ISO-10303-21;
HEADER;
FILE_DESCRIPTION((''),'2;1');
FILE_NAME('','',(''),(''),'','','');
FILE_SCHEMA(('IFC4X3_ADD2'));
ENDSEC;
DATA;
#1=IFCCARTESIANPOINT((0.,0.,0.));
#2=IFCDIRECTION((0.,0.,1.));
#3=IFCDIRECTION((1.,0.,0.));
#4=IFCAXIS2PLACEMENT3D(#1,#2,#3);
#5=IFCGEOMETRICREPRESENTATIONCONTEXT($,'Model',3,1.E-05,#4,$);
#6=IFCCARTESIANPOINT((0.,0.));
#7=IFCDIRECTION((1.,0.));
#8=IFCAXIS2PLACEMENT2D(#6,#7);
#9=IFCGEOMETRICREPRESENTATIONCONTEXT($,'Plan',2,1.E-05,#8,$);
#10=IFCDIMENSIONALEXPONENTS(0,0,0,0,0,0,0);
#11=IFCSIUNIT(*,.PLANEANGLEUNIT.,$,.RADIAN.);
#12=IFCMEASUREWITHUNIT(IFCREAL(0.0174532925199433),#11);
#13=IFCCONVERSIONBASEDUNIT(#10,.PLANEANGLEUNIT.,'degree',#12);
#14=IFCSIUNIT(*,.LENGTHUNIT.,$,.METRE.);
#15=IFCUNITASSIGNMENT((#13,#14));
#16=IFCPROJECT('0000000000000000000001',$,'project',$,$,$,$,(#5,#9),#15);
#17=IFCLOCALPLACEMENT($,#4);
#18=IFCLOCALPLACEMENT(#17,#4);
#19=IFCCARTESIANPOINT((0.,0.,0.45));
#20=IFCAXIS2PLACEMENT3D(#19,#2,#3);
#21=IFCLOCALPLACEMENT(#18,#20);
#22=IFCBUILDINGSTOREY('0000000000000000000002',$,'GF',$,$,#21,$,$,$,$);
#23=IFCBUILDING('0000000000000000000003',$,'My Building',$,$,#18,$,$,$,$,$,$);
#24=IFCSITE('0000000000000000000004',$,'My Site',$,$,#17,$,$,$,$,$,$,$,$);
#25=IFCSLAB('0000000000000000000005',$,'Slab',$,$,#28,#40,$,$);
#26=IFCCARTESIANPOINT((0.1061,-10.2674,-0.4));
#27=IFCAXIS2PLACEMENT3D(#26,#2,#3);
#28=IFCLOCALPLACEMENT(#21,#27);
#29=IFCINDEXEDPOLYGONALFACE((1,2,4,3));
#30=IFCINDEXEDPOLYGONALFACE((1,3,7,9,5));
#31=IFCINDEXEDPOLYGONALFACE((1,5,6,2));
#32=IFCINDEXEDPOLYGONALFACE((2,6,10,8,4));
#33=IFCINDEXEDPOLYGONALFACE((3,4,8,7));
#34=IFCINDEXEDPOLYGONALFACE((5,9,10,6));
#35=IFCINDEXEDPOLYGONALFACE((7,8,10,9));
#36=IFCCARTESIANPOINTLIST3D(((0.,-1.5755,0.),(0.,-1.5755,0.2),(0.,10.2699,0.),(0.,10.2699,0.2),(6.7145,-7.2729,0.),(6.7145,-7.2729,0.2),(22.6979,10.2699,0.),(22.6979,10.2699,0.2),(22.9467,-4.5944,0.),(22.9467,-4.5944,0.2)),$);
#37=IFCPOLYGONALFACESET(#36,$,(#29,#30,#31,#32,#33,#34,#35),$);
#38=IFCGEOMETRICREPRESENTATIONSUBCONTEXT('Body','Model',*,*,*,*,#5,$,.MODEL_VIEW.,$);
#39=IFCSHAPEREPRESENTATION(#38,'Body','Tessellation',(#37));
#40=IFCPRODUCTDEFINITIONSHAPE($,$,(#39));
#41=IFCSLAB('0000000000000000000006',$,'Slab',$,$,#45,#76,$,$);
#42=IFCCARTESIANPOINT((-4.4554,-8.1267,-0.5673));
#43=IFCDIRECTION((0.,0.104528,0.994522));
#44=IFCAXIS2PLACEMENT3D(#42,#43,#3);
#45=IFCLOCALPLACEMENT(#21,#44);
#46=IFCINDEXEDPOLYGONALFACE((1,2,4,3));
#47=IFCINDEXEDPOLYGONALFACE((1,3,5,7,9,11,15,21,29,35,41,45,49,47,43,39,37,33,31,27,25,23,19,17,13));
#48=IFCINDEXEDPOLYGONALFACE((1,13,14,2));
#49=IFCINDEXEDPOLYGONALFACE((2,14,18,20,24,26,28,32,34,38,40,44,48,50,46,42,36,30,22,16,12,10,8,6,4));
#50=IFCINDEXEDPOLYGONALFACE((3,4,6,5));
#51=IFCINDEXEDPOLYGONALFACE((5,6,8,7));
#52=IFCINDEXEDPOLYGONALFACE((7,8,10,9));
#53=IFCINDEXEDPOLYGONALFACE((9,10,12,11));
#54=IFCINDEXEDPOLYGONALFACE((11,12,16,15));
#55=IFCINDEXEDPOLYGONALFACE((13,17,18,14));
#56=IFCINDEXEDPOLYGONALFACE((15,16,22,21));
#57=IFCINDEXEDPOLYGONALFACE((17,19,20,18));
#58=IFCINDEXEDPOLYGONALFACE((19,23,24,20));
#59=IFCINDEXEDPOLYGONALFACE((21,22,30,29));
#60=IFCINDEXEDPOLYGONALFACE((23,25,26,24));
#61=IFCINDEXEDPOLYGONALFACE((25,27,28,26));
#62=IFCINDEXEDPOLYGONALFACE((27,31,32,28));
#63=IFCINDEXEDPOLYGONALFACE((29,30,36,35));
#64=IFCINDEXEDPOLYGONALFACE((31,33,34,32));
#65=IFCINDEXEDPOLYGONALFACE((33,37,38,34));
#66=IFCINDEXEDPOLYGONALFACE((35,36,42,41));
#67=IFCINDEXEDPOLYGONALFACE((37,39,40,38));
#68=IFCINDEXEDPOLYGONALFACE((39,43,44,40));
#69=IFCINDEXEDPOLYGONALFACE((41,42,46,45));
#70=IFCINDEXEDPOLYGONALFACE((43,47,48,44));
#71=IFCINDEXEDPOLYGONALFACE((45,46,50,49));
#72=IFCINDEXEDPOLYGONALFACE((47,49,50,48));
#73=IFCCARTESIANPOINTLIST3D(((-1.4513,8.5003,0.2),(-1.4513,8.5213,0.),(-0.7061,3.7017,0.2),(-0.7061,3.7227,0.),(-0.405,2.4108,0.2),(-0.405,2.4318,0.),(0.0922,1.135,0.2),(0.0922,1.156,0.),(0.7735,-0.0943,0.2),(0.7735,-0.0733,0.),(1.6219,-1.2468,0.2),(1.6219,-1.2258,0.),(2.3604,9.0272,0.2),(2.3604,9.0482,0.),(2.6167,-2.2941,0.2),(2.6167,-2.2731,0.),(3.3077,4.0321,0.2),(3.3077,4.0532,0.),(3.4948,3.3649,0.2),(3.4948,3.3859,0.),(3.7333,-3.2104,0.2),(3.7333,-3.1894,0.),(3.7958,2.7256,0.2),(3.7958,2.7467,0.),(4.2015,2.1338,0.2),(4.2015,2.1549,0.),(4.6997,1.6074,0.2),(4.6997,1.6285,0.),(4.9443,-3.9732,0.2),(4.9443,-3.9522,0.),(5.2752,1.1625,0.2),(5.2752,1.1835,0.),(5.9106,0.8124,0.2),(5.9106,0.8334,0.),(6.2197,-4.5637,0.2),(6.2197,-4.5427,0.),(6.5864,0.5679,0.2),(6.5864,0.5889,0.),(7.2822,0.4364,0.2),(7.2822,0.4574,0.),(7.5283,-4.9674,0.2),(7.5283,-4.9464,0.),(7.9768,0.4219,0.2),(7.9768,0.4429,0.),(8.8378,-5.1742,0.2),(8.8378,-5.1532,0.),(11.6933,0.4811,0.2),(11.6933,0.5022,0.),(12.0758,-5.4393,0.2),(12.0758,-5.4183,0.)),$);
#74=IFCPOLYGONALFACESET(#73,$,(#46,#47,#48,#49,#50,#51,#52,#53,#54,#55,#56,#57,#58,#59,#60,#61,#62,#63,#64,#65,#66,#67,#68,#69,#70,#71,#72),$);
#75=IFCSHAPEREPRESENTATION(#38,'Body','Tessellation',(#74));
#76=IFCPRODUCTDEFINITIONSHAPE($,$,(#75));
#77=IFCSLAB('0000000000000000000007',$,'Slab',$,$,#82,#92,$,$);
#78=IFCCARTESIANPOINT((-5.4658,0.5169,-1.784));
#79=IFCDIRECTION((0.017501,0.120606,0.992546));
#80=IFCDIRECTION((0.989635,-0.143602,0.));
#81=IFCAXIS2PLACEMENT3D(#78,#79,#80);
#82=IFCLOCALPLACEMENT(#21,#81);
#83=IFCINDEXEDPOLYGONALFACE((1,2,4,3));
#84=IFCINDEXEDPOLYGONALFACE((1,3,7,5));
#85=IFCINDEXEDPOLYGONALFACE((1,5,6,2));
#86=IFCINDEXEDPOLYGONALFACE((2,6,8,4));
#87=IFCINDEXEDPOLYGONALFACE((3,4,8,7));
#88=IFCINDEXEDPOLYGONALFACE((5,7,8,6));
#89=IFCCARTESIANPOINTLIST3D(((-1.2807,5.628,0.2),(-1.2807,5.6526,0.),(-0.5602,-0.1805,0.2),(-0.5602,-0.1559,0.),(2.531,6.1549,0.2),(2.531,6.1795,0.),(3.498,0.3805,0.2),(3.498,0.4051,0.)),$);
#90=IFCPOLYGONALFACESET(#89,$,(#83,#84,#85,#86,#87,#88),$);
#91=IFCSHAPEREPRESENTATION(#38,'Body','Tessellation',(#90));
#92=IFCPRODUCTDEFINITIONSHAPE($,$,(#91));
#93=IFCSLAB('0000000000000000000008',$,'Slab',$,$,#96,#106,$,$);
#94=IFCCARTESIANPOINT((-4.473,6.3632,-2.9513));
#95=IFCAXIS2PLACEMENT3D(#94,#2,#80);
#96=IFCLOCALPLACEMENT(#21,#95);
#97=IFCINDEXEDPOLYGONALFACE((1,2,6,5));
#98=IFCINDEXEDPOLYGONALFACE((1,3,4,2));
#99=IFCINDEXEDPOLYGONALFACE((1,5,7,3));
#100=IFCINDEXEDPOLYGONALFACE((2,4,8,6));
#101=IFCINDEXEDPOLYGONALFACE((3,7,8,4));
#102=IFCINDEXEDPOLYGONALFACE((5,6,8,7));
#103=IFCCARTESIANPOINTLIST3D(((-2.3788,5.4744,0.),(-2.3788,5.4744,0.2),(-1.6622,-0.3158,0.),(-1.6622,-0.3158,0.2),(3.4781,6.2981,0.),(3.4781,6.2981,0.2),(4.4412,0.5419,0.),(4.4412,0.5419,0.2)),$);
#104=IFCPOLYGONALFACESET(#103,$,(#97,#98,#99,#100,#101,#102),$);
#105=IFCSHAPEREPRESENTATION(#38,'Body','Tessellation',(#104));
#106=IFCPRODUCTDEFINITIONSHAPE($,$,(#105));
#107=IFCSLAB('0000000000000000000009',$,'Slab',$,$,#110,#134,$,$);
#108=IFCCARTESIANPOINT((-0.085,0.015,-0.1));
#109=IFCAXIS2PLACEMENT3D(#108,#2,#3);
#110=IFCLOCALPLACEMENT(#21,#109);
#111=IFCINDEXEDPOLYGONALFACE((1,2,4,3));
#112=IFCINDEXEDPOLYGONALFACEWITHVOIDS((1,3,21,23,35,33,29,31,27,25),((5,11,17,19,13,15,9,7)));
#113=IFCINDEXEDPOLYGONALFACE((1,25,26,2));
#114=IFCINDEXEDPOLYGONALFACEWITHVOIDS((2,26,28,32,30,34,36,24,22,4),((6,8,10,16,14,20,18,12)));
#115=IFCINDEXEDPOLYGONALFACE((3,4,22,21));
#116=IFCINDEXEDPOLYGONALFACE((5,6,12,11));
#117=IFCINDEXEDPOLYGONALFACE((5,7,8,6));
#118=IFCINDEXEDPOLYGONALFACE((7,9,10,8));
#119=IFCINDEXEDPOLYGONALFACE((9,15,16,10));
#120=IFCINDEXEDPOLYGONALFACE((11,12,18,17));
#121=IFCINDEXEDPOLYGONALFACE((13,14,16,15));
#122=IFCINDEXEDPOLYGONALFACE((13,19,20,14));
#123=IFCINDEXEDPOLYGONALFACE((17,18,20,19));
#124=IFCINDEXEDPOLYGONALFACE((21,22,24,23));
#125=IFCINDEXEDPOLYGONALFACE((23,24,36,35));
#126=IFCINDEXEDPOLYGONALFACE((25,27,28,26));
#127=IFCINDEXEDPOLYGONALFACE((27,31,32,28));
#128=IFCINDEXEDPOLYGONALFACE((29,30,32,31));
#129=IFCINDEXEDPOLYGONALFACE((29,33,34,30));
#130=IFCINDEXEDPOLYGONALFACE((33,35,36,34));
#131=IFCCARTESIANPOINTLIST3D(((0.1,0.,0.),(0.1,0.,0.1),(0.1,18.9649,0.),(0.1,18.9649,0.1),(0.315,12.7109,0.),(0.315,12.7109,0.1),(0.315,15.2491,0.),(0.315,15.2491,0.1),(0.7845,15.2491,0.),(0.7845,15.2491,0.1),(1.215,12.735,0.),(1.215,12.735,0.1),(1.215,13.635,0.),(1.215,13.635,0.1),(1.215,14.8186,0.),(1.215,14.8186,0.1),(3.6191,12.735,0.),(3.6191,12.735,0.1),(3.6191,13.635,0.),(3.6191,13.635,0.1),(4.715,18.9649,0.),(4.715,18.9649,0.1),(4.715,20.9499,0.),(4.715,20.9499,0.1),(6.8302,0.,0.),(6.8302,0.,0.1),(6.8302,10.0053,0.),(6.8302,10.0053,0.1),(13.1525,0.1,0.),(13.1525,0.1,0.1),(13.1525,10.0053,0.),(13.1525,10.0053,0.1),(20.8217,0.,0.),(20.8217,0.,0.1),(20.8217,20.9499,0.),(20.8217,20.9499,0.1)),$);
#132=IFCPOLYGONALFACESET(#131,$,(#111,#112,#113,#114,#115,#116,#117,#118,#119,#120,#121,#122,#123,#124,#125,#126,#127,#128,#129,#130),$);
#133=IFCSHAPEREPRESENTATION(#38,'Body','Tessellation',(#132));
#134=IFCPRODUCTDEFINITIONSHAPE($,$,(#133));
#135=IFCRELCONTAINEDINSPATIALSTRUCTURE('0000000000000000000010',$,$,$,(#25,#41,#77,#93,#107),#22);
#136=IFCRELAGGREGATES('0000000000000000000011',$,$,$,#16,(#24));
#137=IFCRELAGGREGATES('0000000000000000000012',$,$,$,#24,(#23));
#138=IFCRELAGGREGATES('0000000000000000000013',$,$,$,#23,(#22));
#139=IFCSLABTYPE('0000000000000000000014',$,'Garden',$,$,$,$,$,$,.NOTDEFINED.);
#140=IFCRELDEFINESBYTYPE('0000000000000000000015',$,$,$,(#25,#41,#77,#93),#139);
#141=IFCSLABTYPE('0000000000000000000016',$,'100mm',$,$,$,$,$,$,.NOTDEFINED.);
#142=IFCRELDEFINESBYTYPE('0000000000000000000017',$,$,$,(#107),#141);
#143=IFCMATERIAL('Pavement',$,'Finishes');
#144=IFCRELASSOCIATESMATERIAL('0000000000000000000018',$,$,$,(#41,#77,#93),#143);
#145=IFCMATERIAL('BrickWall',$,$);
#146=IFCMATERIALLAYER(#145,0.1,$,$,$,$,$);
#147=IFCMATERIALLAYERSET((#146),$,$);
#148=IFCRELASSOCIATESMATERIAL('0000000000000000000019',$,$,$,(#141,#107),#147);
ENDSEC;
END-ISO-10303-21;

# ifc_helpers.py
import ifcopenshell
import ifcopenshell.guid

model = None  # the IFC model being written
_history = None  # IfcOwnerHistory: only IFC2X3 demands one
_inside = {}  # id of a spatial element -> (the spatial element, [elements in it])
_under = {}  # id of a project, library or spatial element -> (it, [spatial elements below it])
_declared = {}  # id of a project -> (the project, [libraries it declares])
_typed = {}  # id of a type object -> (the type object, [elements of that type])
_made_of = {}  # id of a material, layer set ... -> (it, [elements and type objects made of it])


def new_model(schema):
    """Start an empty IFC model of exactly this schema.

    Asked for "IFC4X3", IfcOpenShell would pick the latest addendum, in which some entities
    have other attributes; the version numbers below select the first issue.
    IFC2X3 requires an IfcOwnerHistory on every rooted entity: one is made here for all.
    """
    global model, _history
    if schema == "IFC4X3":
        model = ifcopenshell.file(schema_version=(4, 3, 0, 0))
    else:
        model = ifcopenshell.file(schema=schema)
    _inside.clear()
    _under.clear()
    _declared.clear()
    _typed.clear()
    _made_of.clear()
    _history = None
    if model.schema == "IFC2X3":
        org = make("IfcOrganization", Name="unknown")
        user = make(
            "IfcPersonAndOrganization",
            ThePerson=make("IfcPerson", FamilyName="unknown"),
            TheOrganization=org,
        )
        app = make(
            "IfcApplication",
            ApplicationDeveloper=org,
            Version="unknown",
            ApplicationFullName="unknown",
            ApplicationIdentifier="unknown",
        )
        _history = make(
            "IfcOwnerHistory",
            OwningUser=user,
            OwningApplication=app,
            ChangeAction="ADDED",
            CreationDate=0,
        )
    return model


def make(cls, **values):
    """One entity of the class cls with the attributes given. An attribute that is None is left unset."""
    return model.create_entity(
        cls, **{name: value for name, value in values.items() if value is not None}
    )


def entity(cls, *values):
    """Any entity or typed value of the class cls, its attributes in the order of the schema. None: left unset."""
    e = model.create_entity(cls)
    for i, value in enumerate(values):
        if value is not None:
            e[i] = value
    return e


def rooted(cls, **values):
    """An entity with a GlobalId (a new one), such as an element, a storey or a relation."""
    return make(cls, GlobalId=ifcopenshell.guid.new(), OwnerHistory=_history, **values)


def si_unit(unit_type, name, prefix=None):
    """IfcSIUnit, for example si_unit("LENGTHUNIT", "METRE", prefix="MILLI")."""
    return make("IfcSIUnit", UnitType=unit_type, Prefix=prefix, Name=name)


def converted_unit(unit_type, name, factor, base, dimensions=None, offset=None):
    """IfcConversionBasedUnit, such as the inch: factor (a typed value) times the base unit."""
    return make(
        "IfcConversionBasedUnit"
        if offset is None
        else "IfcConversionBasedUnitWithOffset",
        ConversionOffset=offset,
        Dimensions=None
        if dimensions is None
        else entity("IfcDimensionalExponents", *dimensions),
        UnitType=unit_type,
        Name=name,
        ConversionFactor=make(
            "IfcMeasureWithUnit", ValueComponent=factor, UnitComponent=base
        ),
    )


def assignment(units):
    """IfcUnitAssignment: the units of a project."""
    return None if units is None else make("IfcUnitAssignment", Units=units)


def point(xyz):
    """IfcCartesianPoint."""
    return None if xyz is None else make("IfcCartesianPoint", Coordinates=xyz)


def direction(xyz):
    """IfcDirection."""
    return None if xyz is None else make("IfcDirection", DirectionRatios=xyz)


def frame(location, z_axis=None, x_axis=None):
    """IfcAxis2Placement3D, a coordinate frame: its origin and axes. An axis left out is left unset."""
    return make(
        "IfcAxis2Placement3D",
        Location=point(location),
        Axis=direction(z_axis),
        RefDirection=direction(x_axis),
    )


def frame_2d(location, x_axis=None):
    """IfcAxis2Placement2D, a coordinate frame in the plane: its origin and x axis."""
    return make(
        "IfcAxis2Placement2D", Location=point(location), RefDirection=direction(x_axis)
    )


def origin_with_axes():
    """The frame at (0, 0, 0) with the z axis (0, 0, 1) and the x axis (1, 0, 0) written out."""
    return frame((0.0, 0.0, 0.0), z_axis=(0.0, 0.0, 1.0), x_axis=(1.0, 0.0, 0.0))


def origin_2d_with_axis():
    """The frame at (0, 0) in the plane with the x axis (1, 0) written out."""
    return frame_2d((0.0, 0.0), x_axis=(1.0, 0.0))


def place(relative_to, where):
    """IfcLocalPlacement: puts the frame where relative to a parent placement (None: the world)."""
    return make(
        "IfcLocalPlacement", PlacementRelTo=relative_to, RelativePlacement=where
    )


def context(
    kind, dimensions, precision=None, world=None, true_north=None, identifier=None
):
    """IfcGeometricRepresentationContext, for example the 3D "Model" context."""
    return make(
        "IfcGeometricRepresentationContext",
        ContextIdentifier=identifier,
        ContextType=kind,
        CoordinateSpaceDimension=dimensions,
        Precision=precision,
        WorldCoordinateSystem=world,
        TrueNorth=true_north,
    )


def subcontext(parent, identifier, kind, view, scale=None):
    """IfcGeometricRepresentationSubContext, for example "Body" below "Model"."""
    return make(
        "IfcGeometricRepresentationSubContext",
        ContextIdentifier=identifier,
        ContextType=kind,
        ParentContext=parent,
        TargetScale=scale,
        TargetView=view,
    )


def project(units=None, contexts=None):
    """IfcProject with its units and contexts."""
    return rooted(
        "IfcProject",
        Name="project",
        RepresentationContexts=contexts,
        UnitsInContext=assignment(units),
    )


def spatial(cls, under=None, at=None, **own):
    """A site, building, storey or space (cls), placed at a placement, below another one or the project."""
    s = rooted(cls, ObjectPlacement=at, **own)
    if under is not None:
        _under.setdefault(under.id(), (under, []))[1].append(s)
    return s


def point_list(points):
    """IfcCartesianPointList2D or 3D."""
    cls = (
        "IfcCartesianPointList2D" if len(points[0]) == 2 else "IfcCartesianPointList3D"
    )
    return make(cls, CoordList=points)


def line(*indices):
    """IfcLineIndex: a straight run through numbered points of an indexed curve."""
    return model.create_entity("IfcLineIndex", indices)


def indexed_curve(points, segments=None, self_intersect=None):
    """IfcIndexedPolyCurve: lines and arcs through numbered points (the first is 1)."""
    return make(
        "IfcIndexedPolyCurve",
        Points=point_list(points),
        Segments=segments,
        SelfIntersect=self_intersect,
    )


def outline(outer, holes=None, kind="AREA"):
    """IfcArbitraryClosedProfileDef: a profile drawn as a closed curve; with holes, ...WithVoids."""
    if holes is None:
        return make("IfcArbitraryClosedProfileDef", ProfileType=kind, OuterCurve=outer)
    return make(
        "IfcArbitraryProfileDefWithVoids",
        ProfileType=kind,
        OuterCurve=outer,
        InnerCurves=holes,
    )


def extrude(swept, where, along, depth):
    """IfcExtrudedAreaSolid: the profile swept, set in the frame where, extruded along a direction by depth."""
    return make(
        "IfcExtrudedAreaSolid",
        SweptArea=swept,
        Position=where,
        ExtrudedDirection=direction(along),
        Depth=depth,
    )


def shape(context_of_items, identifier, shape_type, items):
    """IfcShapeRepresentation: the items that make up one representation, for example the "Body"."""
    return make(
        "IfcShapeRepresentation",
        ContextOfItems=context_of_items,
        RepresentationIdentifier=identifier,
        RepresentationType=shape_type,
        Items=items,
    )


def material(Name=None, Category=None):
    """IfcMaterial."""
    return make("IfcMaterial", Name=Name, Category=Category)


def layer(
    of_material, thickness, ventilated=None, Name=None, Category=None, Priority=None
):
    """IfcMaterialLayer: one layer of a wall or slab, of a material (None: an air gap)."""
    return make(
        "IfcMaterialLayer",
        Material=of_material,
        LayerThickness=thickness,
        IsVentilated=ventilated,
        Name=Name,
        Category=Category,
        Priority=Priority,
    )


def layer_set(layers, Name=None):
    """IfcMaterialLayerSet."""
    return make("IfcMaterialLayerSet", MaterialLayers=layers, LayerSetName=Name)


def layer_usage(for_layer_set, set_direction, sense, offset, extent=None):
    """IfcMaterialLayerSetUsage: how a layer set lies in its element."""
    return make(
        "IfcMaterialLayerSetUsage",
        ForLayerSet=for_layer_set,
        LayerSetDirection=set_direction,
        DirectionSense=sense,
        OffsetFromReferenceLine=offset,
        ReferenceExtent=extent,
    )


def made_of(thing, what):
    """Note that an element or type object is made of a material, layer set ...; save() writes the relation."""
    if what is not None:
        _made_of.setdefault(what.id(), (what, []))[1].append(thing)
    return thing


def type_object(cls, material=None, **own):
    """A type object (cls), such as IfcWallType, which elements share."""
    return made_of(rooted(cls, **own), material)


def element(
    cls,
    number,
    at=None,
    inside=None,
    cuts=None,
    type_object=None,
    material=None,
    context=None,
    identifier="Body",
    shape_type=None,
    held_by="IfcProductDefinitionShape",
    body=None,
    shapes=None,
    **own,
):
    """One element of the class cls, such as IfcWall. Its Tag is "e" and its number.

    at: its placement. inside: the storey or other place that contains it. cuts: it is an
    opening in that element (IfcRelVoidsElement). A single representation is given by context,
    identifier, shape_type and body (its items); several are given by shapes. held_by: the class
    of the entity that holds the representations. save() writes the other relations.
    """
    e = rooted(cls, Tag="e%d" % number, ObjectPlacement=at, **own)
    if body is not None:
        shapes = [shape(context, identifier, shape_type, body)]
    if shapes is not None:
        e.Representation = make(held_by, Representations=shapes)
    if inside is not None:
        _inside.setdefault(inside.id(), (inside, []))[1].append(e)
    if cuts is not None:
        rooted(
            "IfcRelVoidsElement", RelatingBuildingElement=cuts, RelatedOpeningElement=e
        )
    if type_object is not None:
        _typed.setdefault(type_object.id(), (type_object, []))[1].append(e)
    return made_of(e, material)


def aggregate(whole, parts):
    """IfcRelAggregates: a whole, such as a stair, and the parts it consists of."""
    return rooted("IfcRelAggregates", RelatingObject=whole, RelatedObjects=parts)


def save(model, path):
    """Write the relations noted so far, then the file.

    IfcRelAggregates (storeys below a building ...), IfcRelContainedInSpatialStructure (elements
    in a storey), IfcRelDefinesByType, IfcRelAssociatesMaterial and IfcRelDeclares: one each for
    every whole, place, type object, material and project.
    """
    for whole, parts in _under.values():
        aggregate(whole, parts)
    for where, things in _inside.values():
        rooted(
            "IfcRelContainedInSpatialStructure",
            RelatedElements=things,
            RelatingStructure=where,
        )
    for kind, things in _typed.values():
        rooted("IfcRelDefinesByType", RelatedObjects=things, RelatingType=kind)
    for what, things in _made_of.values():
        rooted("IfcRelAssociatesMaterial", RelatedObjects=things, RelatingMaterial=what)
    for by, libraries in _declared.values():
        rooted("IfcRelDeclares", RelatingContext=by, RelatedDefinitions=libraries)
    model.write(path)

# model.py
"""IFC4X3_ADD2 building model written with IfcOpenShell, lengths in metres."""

from ifc_helpers import new_model, entity, si_unit, converted_unit, frame, origin_with_axes, origin_2d_with_axis, place, context, subcontext, project, spatial, line, indexed_curve, outline, extrude, material, layer, layer_set, layer_usage, type_object, element, save


model = new_model("IFC4X3_ADD2")

# Units and contexts
model_context = context("Model", 3, precision=1e-05, world=origin_with_axes())
plan_context = context("Plan", 2, precision=1e-05, world=origin_2d_with_axis())
body_context_1 = subcontext(model_context, "Body", "Model", "MODEL_VIEW")
ifc_project = project(units=[converted_unit("PLANEANGLEUNIT", "degree", entity("IfcReal", 0.0174532925199433), si_unit("PLANEANGLEUNIT", "RADIAN"), dimensions=[0, 0, 0, 0, 0, 0, 0]), si_unit("LENGTHUNIT", "METRE")], contexts=[model_context, plan_context])

# Site, building, storey
site_placement = place(None, origin_with_axes())
site = spatial("IfcSite", under=ifc_project, at=site_placement, Name="My Site")
building_placement = place(site_placement, origin_with_axes())
building = spatial("IfcBuilding", under=site, at=building_placement, Name="My Building")
storey_placement = place(building_placement, frame((0.0, 0.0, 0.45), z_axis=(0.0, 0.0, 1.0), x_axis=(1.0, 0.0, 0.0)))
storey = spatial("IfcBuildingStorey", under=building, at=storey_placement, Name="GF")

# Slabs
slab_type_1 = type_object("IfcSlabType", Name="Garden", PredefinedType="NOTDEFINED")
slab_1_placement = place(storey_placement, frame((0.1061, -10.2674, -0.4), z_axis=(0.0, 0.0, 1.0), x_axis=(1.0, 0.0, 0.0)))
element("IfcSlab", 1, at=slab_1_placement, inside=storey, type_object=slab_type_1, Name="Slab", context=body_context_1, shape_type="SweptSolid", body=[
    extrude(outline(indexed_curve([(22.6979, 10.2699), (0.0, 10.2699), (22.9467, -4.5944), (0.0, -1.5755), (6.7145, -7.2729)], segments=[line(1, 3), line(3, 5), line(5, 4), line(4, 2), line(2, 1)], self_intersect=False)), None, (0.0, 0.0, 1.0), 0.2),
])
ifc_material_1 = material(Name="Pavement", Category="Finishes")
slab_2_placement = place(storey_placement, frame((-4.4554, -8.1267, -0.5673), z_axis=(0.0, 0.104528, 0.994522), x_axis=(1.0, 0.0, 0.0)))
element("IfcSlab", 2, at=slab_2_placement, inside=storey, type_object=slab_type_1, material=ifc_material_1, Name="Slab", context=body_context_1, shape_type="SweptSolid", body=[
    extrude(outline(indexed_curve([(-1.4513, 8.5213), (2.3604, 9.0482), (11.6933, 0.5022), (12.0758, -5.4183), (3.3077, 4.0532), (7.9768, 0.4429), (3.4948, 3.3859), (3.7958, 2.7467), (4.2015, 2.1549), (4.6997, 1.6285), (5.2752, 1.1835), (5.9106, 0.8334), (6.5864, 0.5889), (7.2822, 0.4574), (8.8378, -5.1532), (-0.7061, 3.7227), (7.5283, -4.9464), (6.2197, -4.5427), (4.9443, -3.9522), (3.7333, -3.1894), (2.6167, -2.2731), (1.6219, -1.2258), (0.7735, -0.0733), (0.0922, 1.156), (-0.405, 2.4318)], segments=[line(16, 25), line(25, 24), line(24, 23), line(23, 22), line(22, 21), line(21, 20), line(20, 19), line(19, 18), line(18, 17), line(17, 15), line(15, 4), line(4, 3), line(3, 6), line(6, 14), line(14, 13), line(13, 12), line(12, 11), line(11, 10), line(10, 9), line(9, 8), line(8, 7), line(7, 5), line(5, 2), line(2, 1), line(1, 16)], self_intersect=False)), None, (0.0, -0.104528, 0.994522), 0.2011),
])
slab_3_placement = place(storey_placement, frame((-5.4658, 0.5169, -1.784), z_axis=(0.017501, 0.120606, 0.992546), x_axis=(0.989635, -0.143602, 0.0)))
element("IfcSlab", 3, at=slab_3_placement, inside=storey, type_object=slab_type_1, material=ifc_material_1, Name="Slab", context=body_context_1, shape_type="SweptSolid", body=[
    extrude(outline(indexed_curve([(-1.2807, 5.6526), (2.531, 6.1795), (3.498, 0.4051), (-0.5602, -0.1559)], segments=[line(4, 1), line(1, 2), line(2, 3), line(3, 4)], self_intersect=False)), None, (0.0, -0.121869, 0.992546), 0.2015),
])
slab_4_placement = place(storey_placement, frame((-4.473, 6.3632, -2.9513), z_axis=(0.0, 0.0, 1.0), x_axis=(0.989635, -0.143602, 0.0)))
element("IfcSlab", 4, at=slab_4_placement, inside=storey, type_object=slab_type_1, material=ifc_material_1, Name="Slab", context=body_context_1, shape_type="SweptSolid", body=[
    extrude(outline(indexed_curve([(4.4412, 0.5419), (3.4781, 6.2981), (-2.3788, 5.4744), (-1.6622, -0.3158)], segments=[line(3, 2), line(2, 1), line(1, 4), line(4, 3)], self_intersect=False)), None, (0.0, 0.0, 1.0), 0.2),
])
ifc_material_2 = material(Name="BrickWall")
ifc_layer_1 = layer(ifc_material_2, 0.1)
ifc_layer_set_1 = layer_set([ifc_layer_1])
ifc_layer_usage_1 = layer_usage(ifc_layer_set_1, "AXIS3", "POSITIVE", 0.0)
slab_type_2 = type_object("IfcSlabType", Name="100mm", PredefinedType="NOTDEFINED", material=ifc_layer_set_1)
slab_5_placement = place(storey_placement, frame((-0.085, 0.015, -0.1), z_axis=(0.0, 0.0, 1.0), x_axis=(1.0, 0.0, 0.0)))
element("IfcSlab", 5, at=slab_5_placement, inside=storey, type_object=slab_type_2, material=ifc_layer_usage_1, Name="Slab", context=body_context_1, shape_type="SweptSolid", body=[
    extrude(outline(indexed_curve([(0.1, 18.9649), (0.1, 0.0), (6.8302, 0.0), (6.8302, 10.0053), (13.1525, 10.0053), (13.1525, 0.1), (20.8217, 0.0), (20.8217, 20.9499), (4.715, 20.9499), (4.715, 18.9649), (3.6191, 13.635), (1.215, 13.635), (1.215, 14.8186), (0.7845, 15.2491), (0.315, 15.2491), (0.315, 12.7109), (1.215, 12.735), (3.6191, 12.735)], segments=[line(8, 7), line(7, 6), line(6, 5), line(5, 4), line(4, 3), line(3, 2), line(2, 1), line(1, 10), line(10, 9), line(9, 8)], self_intersect=False), holes=[indexed_curve([(0.1, 18.9649), (0.1, 0.0), (6.8302, 0.0), (6.8302, 10.0053), (13.1525, 10.0053), (13.1525, 0.1), (20.8217, 0.0), (20.8217, 20.9499), (4.715, 20.9499), (4.715, 18.9649), (3.6191, 13.635), (1.215, 13.635), (1.215, 14.8186), (0.7845, 15.2491), (0.315, 15.2491), (0.315, 12.7109), (1.215, 12.735), (3.6191, 12.735)], segments=[line(12, 11), line(11, 18), line(18, 17), line(17, 16), line(16, 15), line(15, 14), line(14, 13), line(13, 12)], self_intersect=False)]), None, (0.0, 0.0, 1.0), 0.1),
])

save(model, "model.ifc")
